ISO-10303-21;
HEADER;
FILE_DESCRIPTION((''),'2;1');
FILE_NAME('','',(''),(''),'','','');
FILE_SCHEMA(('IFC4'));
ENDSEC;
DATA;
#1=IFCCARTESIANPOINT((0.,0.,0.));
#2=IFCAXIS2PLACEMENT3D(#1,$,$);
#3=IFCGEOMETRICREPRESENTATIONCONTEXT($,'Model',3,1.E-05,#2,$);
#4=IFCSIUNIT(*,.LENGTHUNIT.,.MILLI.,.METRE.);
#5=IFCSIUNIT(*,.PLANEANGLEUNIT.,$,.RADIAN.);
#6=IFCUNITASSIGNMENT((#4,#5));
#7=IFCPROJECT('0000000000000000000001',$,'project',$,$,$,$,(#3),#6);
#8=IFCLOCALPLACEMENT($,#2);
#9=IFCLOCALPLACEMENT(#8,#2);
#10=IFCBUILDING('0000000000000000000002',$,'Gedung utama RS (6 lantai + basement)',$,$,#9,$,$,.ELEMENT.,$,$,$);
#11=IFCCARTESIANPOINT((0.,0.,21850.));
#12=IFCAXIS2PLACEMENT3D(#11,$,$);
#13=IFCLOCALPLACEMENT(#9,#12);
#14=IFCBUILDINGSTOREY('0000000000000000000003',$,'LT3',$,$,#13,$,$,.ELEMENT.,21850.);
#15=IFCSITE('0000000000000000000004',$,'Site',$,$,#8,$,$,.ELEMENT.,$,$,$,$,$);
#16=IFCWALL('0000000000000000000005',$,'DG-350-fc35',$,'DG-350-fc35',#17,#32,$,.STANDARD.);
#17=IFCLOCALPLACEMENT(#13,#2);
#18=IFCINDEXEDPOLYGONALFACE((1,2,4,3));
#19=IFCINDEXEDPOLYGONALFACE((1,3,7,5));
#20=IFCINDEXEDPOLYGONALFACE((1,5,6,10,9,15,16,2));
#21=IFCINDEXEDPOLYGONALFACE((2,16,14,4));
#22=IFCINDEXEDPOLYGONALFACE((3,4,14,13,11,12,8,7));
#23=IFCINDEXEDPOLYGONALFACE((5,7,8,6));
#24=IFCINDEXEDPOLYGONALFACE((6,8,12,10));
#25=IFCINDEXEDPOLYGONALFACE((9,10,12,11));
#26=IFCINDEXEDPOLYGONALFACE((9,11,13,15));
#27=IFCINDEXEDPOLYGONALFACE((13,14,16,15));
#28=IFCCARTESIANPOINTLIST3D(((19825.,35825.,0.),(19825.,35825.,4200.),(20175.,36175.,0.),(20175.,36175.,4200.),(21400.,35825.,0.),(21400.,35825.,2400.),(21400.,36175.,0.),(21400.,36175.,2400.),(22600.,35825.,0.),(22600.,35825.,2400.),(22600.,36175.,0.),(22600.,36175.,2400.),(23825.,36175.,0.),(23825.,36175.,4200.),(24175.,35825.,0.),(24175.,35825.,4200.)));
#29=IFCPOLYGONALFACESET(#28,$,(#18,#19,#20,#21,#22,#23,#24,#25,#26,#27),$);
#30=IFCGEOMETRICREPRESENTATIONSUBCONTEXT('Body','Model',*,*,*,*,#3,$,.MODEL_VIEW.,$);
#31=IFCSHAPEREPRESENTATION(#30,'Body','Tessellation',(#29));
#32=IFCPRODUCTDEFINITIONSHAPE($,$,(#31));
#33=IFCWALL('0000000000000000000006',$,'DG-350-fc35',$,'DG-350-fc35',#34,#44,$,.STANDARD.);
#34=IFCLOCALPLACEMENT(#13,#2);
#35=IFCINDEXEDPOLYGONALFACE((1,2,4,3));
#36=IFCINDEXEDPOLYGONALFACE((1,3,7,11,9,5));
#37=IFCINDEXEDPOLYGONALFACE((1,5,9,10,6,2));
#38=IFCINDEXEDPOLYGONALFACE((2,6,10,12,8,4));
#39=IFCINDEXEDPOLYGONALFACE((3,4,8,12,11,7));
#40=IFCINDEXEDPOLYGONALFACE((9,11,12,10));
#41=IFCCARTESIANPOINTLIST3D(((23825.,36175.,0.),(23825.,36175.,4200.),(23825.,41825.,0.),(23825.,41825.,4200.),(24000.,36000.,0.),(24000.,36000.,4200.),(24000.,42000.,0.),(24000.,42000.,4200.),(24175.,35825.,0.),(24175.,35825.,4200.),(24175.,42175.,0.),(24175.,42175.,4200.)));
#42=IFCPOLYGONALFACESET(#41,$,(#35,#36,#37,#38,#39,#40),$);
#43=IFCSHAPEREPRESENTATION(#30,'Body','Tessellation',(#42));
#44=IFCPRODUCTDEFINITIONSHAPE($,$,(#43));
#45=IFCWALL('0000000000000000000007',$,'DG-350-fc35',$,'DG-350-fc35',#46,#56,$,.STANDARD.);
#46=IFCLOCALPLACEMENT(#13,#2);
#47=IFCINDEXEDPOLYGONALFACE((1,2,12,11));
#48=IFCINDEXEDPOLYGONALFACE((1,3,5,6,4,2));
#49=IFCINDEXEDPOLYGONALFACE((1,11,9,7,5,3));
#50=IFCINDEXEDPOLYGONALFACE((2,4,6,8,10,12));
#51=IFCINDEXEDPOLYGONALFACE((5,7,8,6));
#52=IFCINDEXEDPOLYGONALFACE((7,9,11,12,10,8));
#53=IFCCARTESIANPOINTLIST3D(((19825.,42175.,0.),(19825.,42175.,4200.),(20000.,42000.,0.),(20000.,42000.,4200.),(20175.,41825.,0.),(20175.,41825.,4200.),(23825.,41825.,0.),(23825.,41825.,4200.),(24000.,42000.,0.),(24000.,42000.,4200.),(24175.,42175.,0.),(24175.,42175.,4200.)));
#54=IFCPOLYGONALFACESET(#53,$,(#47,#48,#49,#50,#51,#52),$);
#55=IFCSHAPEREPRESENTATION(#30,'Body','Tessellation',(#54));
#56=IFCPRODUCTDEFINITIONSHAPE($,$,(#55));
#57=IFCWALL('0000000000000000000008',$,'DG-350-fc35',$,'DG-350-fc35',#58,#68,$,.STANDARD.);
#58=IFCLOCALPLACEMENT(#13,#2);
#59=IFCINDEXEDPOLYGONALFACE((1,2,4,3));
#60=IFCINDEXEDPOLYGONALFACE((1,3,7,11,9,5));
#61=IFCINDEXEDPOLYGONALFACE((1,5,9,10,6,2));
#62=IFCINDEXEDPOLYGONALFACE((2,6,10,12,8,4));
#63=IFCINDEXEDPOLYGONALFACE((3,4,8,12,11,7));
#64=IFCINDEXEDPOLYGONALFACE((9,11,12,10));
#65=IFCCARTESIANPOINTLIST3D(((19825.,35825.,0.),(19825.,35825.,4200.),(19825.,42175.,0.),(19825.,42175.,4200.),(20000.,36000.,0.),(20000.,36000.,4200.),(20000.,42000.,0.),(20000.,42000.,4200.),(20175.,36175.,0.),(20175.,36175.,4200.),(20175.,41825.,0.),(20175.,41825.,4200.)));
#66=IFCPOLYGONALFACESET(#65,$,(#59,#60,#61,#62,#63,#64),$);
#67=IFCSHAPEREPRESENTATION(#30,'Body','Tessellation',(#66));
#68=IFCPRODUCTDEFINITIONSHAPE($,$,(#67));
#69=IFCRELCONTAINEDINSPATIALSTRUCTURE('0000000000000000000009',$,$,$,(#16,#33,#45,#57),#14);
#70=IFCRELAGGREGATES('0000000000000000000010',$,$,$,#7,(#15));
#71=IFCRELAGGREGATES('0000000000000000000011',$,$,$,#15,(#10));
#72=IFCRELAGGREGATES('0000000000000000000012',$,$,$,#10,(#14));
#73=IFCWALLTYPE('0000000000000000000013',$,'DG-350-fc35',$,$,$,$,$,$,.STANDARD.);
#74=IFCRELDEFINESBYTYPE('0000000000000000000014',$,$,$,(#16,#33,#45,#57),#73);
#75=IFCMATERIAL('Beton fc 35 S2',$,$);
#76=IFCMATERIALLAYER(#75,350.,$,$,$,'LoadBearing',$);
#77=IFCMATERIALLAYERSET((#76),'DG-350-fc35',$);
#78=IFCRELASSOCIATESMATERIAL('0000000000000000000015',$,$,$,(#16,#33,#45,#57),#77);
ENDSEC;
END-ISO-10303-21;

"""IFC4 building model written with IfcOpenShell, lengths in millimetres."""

from ifc_helpers import new_model, si_unit, frame, frame_2d, origin, place, context, subcontext, project, spatial, polyline, rectangle, outline, extrude, material, layer, layer_set, layer_usage, type_object, element, save


model = new_model("IFC4")

# Units and contexts
model_context = context("Model", 3, precision=1e-05, world=origin())
body_context = subcontext(model_context, "Body", "Model", "MODEL_VIEW")
ifc_project = project(units=[si_unit("LENGTHUNIT", "METRE", prefix="MILLI"), si_unit("PLANEANGLEUNIT", "RADIAN")], contexts=[model_context])

# Site, building, storey
site_placement = place(None, origin())
site = spatial("IfcSite", under=ifc_project, at=site_placement, Name="Site", CompositionType="ELEMENT")
building_placement = place(site_placement, origin())
building = spatial("IfcBuilding", under=site, at=building_placement, Name="Gedung utama RS (6 lantai + basement)", CompositionType="ELEMENT")
storey_placement = place(building_placement, frame((0.0, 0.0, 21850.0)))
storey = spatial("IfcBuildingStorey", under=building, at=storey_placement, Name="LT3", CompositionType="ELEMENT", Elevation=21850.0)

# Wall, opening
ifc_material_1 = material(Name="Beton fc 35 S2")
ifc_layer_1 = layer(ifc_material_1, 350.0, Category="LoadBearing")
ifc_layer_set_1 = layer_set([ifc_layer_1], Name="DG-350-fc35")
ifc_layer_usage_1 = layer_usage(ifc_layer_set_1, "AXIS2", "NEGATIVE", 175.0)
wall_type_1 = type_object("IfcWallType", Name="DG-350-fc35", PredefinedType="STANDARD")
wall_1_placement = place(storey_placement, frame((20000.0, 36000.0, 0.0), z_axis=(0.0, 0.0, 1.0), x_axis=(1.0, 0.0, 0.0)))
wall_1 = element("IfcWall", 1, at=wall_1_placement, inside=storey, type_object=wall_type_1, material=ifc_layer_usage_1, Name="DG-350-fc35", ObjectType="DG-350-fc35", PredefinedType="STANDARD", context=body_context, shape_type="SweptSolid", body=[
    extrude(outline(polyline([(-175.0, -175.0), (0.0, 0.0), (175.0, 175.0), (3825.0, 175.0), (4000.0, 0.0), (4175.0, -175.0), (-175.0, -175.0)])), origin(), (0.0, 0.0, 1.0), 4200.0),
])
opening_1_placement = place(wall_1_placement, frame((1400.0, 0.0, 0.0), z_axis=(0.0, 0.0, 1.0), x_axis=(1.0, 0.0, 0.0)))
element("IfcOpeningElement", 2, at=opening_1_placement, cuts=wall_1, PredefinedType="OPENING", context=body_context, shape_type="SweptSolid", body=[
    extrude(rectangle(XDim=1200.0, YDim=370.0, at=frame_2d((600.0, 0.0))), origin(), (0.0, 0.0, 1.0), 2400.0),
])

# Walls
wall_2_placement = place(storey_placement, frame((24000.0, 36000.0, 0.0), z_axis=(0.0, 0.0, 1.0), x_axis=(0.0, 1.0, 0.0)))
element("IfcWall", 3, at=wall_2_placement, inside=storey, type_object=wall_type_1, material=ifc_layer_usage_1, Name="DG-350-fc35", ObjectType="DG-350-fc35", PredefinedType="STANDARD", context=body_context, shape_type="SweptSolid", body=[
    extrude(outline(polyline([(-175.0, -175.0), (0.0, 0.0), (175.0, 175.0), (5825.0, 175.0), (6000.0, 0.0), (6175.0, -175.0), (-175.0, -175.0)])), origin(), (0.0, 0.0, 1.0), 4200.0),
])
wall_3_placement = place(storey_placement, frame((24000.0, 42000.0, 0.0), z_axis=(0.0, 0.0, 1.0), x_axis=(-1.0, 0.0, 0.0)))
element("IfcWall", 4, at=wall_3_placement, inside=storey, type_object=wall_type_1, material=ifc_layer_usage_1, Name="DG-350-fc35", ObjectType="DG-350-fc35", PredefinedType="STANDARD", context=body_context, shape_type="SweptSolid", body=[
    extrude(outline(polyline([(-175.0, -175.0), (0.0, 0.0), (175.0, 175.0), (3825.0, 175.0), (4000.0, 0.0), (4175.0, -175.0), (-175.0, -175.0)])), origin(), (0.0, 0.0, 1.0), 4200.0),
])
wall_4_placement = place(storey_placement, frame((20000.0, 42000.0, 0.0), z_axis=(0.0, 0.0, 1.0), x_axis=(0.0, -1.0, 0.0)))
element("IfcWall", 5, at=wall_4_placement, inside=storey, type_object=wall_type_1, material=ifc_layer_usage_1, Name="DG-350-fc35", ObjectType="DG-350-fc35", PredefinedType="STANDARD", context=body_context, shape_type="SweptSolid", body=[
    extrude(outline(polyline([(-175.0, -175.0), (0.0, 0.0), (175.0, 175.0), (5825.0, 175.0), (6000.0, 0.0), (6175.0, -175.0), (-175.0, -175.0)])), origin(), (0.0, 0.0, 1.0), 4200.0),
])

save(model, "model.ifc")
